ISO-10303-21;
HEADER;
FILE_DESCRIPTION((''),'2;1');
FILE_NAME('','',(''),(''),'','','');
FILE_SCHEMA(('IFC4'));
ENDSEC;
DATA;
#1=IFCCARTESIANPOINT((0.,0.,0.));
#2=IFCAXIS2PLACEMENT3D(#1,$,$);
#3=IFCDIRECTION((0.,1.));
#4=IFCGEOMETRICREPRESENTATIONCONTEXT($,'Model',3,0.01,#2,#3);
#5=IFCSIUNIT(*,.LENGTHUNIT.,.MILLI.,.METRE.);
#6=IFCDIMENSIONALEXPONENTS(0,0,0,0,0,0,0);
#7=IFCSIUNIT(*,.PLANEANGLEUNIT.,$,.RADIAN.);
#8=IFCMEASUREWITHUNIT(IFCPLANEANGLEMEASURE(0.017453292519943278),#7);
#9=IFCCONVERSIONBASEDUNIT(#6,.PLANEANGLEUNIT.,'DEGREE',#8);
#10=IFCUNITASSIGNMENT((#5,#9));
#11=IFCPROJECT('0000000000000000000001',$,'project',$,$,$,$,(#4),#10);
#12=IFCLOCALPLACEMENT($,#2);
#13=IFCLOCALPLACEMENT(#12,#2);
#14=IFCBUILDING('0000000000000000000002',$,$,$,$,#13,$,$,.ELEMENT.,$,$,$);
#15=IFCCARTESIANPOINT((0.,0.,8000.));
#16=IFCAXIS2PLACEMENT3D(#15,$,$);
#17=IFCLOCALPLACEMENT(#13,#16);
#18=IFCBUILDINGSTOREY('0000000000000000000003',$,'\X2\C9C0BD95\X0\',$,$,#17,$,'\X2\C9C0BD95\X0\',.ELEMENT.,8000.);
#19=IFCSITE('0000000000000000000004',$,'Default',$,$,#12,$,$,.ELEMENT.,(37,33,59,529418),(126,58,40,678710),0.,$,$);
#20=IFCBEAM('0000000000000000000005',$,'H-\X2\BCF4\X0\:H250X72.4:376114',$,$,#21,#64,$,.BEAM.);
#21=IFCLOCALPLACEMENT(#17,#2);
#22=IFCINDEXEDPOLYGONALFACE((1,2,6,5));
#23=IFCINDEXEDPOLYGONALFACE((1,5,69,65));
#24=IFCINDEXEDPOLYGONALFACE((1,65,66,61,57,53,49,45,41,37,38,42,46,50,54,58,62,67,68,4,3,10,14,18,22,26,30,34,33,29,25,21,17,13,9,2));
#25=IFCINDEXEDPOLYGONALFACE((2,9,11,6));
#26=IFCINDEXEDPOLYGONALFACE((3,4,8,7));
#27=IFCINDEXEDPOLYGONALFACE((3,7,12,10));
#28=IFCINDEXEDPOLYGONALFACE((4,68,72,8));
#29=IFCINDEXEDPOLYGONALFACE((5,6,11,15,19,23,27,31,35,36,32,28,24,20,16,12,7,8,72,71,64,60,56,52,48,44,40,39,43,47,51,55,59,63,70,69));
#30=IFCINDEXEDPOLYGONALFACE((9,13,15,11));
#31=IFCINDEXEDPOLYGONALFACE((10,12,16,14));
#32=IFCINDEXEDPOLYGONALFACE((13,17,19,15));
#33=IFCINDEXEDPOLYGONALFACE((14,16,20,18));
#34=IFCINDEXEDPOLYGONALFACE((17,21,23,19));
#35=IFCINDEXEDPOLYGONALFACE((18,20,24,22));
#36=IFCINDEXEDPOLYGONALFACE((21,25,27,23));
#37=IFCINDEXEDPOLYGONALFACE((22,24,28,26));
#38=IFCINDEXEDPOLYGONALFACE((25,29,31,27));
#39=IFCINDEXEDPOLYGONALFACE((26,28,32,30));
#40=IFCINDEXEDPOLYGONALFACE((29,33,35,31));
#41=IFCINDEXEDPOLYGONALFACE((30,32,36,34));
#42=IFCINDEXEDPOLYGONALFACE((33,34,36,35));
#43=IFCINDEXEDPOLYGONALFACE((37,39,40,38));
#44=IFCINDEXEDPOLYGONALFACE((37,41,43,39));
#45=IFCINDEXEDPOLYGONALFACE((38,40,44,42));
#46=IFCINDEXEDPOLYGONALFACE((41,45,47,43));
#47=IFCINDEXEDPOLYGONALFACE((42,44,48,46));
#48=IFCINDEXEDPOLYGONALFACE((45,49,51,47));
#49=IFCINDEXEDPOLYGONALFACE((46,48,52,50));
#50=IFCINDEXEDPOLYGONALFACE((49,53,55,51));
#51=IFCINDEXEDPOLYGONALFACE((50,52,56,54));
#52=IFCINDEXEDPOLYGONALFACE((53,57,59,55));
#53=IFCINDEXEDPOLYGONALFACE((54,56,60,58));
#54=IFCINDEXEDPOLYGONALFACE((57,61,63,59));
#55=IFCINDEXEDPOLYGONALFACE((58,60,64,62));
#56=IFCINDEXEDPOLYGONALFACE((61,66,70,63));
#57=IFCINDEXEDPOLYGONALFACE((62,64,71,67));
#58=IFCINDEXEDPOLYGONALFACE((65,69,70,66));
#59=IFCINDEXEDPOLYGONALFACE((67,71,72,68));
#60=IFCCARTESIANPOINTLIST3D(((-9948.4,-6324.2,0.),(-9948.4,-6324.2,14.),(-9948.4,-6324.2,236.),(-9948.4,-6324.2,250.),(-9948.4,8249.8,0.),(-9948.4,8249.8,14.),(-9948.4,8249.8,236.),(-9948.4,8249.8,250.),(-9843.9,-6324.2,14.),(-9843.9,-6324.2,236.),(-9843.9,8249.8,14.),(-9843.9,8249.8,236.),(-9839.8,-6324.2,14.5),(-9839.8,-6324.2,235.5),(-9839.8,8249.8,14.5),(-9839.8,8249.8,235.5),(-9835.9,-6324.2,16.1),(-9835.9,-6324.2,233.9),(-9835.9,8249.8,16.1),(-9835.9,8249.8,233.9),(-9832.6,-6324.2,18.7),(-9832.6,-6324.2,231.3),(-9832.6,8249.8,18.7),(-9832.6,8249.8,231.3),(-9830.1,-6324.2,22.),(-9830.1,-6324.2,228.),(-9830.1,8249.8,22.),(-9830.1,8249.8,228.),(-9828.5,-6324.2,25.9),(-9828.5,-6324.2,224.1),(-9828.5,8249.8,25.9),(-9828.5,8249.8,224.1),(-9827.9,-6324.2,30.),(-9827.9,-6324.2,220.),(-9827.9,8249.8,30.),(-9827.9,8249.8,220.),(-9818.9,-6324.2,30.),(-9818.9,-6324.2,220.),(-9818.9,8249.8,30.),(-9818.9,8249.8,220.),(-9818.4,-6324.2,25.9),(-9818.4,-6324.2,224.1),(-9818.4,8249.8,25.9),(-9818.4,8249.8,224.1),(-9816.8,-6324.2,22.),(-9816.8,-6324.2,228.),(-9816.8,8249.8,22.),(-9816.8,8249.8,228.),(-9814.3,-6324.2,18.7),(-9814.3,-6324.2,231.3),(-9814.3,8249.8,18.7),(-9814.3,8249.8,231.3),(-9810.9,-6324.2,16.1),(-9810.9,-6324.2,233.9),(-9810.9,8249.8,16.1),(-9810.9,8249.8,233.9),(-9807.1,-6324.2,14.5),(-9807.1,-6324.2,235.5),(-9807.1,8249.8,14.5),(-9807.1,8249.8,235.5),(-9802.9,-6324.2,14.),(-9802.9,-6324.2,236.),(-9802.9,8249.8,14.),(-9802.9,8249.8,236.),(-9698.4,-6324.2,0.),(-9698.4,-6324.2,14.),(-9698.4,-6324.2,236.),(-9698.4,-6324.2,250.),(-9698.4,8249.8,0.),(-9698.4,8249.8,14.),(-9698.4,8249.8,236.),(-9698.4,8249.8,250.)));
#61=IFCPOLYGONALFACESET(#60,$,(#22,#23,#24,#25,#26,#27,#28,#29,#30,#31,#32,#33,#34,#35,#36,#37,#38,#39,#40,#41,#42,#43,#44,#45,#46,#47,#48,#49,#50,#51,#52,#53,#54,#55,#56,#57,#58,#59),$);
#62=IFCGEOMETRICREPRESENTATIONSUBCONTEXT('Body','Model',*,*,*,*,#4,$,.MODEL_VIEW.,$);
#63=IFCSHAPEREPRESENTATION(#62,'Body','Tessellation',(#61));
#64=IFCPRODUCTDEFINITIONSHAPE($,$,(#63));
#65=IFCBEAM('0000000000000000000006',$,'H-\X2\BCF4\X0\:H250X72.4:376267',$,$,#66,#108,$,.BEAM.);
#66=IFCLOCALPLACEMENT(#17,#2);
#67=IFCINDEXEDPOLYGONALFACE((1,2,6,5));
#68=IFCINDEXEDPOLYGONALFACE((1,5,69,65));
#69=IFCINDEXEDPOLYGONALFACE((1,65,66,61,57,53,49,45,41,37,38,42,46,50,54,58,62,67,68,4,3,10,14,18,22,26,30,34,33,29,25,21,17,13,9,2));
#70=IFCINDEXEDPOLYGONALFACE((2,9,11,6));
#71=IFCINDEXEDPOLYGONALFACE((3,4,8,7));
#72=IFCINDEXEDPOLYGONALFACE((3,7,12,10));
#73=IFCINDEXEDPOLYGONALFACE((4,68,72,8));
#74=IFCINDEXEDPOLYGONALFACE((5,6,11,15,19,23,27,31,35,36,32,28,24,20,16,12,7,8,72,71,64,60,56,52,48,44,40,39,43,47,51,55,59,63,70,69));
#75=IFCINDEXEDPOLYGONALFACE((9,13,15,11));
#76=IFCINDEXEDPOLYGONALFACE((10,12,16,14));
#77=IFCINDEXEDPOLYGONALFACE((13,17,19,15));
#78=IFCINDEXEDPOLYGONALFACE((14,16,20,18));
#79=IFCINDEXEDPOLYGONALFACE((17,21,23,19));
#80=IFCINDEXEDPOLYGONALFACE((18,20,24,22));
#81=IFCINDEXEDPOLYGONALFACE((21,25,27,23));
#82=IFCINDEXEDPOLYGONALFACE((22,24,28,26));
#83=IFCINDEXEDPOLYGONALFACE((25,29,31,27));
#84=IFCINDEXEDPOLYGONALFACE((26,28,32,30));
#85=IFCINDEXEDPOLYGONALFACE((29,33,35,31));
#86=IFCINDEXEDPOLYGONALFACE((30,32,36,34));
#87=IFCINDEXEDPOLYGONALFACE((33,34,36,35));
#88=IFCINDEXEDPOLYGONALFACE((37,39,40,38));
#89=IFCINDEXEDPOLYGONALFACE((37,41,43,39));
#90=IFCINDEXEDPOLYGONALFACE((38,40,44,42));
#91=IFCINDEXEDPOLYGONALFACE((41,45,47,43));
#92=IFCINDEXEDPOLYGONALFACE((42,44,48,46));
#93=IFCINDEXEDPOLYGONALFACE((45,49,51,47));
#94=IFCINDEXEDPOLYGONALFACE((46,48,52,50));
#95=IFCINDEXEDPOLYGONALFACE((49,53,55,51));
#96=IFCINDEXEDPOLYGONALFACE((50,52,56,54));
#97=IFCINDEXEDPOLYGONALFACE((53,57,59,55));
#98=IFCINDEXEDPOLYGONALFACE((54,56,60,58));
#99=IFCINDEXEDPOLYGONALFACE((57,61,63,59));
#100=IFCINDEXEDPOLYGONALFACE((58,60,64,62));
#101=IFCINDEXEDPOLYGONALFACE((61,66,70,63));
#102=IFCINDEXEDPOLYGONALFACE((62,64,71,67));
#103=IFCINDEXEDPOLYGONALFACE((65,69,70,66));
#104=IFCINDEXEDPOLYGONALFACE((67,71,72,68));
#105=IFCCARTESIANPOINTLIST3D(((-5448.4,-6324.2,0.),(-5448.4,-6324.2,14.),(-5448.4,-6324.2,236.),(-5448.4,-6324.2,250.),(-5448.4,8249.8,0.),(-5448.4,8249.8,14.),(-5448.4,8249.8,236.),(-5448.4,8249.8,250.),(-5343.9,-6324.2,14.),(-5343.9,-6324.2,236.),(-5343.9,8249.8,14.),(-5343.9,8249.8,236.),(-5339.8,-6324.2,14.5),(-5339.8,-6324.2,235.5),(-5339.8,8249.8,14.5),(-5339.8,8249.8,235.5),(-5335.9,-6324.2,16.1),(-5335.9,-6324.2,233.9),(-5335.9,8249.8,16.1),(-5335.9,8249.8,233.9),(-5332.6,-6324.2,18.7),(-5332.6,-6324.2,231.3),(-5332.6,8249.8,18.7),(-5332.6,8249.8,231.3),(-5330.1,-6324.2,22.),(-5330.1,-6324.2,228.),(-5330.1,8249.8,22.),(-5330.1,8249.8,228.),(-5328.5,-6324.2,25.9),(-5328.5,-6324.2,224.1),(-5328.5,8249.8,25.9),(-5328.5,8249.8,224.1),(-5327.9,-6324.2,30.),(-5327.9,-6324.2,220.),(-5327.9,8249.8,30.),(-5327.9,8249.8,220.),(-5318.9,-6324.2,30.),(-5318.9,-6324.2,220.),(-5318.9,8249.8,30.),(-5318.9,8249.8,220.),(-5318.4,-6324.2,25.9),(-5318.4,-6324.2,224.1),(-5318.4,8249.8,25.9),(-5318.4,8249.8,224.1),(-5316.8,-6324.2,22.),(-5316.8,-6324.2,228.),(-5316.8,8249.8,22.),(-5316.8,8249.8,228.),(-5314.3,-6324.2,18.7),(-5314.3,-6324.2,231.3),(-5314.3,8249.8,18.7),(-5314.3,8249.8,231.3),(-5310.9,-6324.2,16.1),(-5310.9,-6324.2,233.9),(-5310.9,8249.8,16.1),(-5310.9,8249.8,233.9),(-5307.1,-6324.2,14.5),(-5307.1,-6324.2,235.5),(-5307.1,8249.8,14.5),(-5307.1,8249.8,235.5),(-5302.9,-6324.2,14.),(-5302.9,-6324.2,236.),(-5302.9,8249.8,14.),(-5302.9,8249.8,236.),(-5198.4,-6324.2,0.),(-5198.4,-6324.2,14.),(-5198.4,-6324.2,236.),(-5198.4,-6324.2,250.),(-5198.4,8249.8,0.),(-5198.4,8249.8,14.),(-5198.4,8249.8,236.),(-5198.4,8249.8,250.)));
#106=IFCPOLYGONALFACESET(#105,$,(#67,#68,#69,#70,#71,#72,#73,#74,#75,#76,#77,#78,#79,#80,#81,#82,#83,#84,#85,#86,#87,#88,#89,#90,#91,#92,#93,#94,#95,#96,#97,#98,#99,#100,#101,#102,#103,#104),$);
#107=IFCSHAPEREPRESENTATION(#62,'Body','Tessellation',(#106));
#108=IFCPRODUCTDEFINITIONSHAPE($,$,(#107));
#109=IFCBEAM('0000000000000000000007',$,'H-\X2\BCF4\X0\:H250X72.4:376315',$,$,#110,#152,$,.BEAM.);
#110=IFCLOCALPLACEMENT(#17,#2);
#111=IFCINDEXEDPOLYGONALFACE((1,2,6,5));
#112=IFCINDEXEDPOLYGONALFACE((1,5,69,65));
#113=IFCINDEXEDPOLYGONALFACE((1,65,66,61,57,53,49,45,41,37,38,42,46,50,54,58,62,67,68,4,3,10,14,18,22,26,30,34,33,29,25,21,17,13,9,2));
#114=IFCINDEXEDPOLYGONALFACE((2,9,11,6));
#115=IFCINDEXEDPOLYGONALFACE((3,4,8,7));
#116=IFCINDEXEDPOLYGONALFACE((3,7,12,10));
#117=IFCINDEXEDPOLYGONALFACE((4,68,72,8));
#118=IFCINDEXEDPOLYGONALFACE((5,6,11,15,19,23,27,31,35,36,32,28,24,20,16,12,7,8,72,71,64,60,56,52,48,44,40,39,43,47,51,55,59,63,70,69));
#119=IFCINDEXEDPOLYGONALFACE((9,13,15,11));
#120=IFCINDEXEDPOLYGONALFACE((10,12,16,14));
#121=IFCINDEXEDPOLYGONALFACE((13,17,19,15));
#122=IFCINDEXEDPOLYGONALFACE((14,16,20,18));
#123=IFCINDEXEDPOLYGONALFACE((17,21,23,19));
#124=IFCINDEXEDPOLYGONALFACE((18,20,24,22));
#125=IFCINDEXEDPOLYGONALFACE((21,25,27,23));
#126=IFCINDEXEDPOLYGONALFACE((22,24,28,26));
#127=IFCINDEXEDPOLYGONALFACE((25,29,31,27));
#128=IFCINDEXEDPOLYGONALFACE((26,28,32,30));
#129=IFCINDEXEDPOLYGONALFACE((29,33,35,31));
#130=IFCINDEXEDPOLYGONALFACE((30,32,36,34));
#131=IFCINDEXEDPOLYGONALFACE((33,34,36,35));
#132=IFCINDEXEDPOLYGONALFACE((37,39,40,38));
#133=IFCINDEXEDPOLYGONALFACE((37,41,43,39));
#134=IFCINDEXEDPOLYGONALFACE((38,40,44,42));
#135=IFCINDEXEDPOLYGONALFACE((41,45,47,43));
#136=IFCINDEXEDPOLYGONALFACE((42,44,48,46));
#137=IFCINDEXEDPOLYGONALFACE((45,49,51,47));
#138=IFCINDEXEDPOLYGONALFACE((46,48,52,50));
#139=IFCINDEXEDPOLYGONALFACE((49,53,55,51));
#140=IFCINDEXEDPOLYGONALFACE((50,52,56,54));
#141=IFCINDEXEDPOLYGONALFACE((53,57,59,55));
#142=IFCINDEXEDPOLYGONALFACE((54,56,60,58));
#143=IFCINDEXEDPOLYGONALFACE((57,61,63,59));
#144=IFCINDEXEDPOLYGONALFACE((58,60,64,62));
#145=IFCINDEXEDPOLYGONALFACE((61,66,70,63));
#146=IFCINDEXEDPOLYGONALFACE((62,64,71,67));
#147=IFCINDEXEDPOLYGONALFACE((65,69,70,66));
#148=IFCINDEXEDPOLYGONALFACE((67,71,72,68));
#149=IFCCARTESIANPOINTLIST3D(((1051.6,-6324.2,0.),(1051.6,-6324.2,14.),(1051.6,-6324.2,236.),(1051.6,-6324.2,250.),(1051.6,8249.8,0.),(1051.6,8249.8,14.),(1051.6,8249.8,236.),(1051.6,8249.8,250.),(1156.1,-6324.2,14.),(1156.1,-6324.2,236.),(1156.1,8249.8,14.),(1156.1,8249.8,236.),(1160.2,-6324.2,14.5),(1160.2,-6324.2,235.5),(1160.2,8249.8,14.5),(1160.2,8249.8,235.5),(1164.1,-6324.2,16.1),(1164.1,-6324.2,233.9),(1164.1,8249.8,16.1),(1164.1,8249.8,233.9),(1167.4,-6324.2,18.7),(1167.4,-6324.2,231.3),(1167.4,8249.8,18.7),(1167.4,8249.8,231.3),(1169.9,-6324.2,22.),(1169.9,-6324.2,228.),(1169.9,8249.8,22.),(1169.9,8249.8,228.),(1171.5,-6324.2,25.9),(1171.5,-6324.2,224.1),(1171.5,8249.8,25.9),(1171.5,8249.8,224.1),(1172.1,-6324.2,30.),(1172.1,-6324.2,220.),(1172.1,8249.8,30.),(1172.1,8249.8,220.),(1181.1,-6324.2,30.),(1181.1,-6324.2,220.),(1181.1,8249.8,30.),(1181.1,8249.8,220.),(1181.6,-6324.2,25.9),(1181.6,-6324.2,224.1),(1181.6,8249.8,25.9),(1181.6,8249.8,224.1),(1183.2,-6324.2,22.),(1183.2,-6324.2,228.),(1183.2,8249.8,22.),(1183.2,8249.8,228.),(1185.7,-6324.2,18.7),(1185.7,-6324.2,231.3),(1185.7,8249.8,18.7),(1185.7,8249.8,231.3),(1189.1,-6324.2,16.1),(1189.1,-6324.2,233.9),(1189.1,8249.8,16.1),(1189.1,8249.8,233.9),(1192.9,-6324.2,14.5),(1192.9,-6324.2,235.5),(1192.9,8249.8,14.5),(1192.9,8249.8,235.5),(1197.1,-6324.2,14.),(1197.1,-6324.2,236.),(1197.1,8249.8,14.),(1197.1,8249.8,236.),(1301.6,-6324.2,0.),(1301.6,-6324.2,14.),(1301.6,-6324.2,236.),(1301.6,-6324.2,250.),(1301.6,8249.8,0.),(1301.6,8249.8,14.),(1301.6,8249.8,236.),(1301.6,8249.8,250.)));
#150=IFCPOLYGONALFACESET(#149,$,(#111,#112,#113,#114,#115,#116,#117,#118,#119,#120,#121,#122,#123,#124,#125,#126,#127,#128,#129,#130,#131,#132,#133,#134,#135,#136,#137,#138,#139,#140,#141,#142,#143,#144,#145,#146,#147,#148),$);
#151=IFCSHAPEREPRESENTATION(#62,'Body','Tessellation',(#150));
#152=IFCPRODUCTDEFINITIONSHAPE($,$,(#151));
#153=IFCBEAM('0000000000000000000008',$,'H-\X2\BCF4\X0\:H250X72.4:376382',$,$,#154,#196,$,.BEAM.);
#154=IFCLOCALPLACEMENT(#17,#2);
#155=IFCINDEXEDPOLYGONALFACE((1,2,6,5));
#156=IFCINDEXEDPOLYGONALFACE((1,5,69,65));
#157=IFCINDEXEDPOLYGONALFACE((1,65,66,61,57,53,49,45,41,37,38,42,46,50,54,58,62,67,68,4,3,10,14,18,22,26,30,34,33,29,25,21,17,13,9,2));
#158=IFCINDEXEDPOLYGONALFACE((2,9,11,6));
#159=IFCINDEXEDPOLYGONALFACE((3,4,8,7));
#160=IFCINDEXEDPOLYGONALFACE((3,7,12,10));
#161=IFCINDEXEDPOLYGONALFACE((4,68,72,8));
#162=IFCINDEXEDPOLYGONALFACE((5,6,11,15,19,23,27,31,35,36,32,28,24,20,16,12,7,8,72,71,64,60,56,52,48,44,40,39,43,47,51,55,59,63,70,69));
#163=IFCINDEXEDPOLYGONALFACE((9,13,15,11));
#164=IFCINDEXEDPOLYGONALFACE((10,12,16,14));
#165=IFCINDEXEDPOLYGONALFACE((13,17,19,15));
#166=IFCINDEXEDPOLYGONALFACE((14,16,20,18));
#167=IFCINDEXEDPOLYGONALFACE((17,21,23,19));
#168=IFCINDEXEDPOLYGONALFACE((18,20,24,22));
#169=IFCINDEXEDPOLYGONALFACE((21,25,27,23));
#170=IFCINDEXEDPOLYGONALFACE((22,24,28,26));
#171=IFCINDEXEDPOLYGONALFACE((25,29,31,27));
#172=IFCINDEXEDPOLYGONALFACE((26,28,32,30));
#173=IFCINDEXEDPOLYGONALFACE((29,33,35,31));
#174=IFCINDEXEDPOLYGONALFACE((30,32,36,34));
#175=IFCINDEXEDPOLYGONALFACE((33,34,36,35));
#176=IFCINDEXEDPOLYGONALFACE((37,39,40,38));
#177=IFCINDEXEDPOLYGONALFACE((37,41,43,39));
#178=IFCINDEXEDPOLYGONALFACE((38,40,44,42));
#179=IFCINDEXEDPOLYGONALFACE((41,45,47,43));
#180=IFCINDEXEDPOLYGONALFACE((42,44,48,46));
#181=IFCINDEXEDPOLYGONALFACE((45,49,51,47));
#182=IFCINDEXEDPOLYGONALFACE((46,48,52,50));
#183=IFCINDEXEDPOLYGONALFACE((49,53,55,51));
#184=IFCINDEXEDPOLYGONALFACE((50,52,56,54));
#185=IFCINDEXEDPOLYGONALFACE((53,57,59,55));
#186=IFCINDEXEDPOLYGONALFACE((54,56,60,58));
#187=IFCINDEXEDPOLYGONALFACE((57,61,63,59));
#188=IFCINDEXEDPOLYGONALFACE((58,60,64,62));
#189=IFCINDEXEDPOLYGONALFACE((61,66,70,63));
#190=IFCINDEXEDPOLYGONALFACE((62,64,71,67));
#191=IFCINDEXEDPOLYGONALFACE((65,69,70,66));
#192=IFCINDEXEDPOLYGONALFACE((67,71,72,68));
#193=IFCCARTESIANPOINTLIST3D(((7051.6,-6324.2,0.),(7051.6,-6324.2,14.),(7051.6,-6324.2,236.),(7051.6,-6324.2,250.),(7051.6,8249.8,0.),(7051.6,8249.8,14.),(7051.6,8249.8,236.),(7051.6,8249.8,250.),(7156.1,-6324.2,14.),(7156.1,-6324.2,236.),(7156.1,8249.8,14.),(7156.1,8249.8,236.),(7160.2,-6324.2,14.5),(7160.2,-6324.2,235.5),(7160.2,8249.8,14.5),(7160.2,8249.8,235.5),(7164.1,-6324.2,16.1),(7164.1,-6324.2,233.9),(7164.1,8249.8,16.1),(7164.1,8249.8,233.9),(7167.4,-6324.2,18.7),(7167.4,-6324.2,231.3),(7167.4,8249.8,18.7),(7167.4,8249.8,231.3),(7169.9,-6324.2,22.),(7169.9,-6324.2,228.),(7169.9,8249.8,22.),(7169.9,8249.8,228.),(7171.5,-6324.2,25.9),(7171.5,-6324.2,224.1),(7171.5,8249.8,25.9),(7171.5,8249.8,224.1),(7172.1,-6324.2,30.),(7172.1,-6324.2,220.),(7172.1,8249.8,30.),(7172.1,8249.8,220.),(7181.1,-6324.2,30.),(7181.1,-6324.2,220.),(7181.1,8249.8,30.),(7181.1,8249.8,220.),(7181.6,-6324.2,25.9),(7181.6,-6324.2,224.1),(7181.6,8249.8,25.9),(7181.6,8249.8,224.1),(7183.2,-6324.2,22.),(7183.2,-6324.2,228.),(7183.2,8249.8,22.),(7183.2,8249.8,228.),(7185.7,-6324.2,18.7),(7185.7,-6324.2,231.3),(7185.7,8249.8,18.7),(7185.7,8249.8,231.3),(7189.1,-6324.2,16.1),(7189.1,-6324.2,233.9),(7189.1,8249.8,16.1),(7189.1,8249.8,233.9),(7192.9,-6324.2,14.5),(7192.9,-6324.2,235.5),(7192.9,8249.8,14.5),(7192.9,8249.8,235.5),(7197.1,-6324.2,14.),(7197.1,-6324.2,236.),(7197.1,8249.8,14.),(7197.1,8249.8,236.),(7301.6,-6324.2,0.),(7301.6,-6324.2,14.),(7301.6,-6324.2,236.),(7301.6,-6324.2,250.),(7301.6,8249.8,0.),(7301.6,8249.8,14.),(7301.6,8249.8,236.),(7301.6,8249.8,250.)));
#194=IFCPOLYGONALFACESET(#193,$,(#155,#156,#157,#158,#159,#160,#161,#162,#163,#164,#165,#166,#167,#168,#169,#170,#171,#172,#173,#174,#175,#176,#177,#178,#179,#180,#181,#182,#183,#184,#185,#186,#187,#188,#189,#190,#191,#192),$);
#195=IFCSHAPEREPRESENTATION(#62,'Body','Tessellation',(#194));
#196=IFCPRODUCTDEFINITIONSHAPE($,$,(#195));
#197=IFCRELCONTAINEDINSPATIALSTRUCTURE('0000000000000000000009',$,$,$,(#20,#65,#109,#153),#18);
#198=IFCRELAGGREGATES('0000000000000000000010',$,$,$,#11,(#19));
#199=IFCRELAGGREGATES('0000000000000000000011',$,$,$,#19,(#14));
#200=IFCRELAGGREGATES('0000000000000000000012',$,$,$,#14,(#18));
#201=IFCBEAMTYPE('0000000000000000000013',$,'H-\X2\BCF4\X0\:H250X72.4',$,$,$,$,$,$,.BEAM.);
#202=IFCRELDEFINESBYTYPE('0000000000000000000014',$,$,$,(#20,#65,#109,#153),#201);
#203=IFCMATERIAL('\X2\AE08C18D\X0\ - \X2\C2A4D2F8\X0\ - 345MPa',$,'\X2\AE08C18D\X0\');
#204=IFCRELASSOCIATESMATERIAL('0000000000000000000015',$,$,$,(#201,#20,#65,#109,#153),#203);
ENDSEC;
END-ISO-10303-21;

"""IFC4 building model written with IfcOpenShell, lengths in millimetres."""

from ifc_helpers import new_model, entity, si_unit, converted_unit, direction, frame, origin, place, context, subcontext, project, spatial, line, arc, indexed_curve, outline, extrude, source, transform, mapped, material, type_object, type_shapes, element, save


model = new_model("IFC4")

# Units and contexts
model_context = context("Model", 3, precision=0.01, world=origin(), true_north=direction((0.0, 1.0)))
body_context = subcontext(model_context, "Body", "Model", "MODEL_VIEW")
ifc_project = project(units=[si_unit("LENGTHUNIT", "METRE", prefix="MILLI"), converted_unit("PLANEANGLEUNIT", "DEGREE", entity("IfcPlaneAngleMeasure", 0.017453292519943278), si_unit("PLANEANGLEUNIT", "RADIAN"), dimensions=[0, 0, 0, 0, 0, 0, 0])], contexts=[model_context])

# Site, building, storey
site_placement = place(None, origin())
site = spatial("IfcSite", under=ifc_project, at=site_placement, Name="Default", CompositionType="ELEMENT", RefLatitude=(37, 33, 59, 529418), RefLongitude=(126, 58, 40, 678710), RefElevation=0.0)
building_placement = place(site_placement, origin())
building = spatial("IfcBuilding", under=site, at=building_placement, CompositionType="ELEMENT")
storey_placement = place(building_placement, frame((0.0, 0.0, 8000.0)))
storey = spatial("IfcBuildingStorey", under=building, at=storey_placement, Name="지붕", LongName="지붕", CompositionType="ELEMENT", Elevation=8000.0)

# Beams
ifc_material = material(Name="금속 - 스틸 - 345MPa", Category="금속")
beam_type_1 = type_object("IfcBeamType", Name="H-보:H250X72.4", PredefinedType="BEAM", material=ifc_material)
shared_shape_1 = source(origin(), body_context, "Body", "SweptSolid", [
    extrude(outline(indexed_curve([(-125.0, -111.0), (-125.0, -125.0), (125.0, -125.0), (125.0, -111.0), (20.5, -111.0), (9.2, -106.3), (4.5, -95.0), (4.5, 95.0), (9.2, 106.3), (20.5, 111.0), (125.0, 111.0), (125.0, 125.0), (-125.0, 125.0), (-125.0, 111.0), (-20.5, 111.0), (-9.2, 106.3), (-4.5, 95.0), (-4.5, -95.0), (-9.2, -106.3), (-20.5, -111.0)], segments=[line(1, 2, 3, 4, 5), arc(5, 6, 7), line(7, 8), arc(8, 9, 10), line(10, 11, 12, 13, 14, 15), arc(15, 16, 17), line(17, 18), arc(18, 19, 20), line(20, 1)], self_intersect=False)), frame((-7287.0, 0.0, 0.0), z_axis=(-1.0, 0.0, 0.0), x_axis=(0.0, -1.0, 0.0)), (0.0, 0.0, -1.0), 14574.0),
])
type_shapes(beam_type_1, [shared_shape_1])
for number, where, z_axis, x_axis, name in (
    (1, (-9823.4, 962.8, 125.0), (0.0, 0.0, 1.0), (0.0, -1.0, 0.0), "H-보:H250X72.4:376114"),
    (2, (-5323.4, 962.8, 125.0), (0.0, 0.0, 1.0), (0.0, -1.0, 0.0), "H-보:H250X72.4:376267"),
    (3, (1176.6, 962.8, 125.0), (0.0, 0.0, 1.0), (0.0, -1.0, 0.0), "H-보:H250X72.4:376315"),
    (4, (7176.6, 962.8, 125.0), (0.0, 0.0, 1.0), (0.0, -1.0, 0.0), "H-보:H250X72.4:376382"),
):
    element("IfcBeam", number, at=place(storey_placement, frame(where, z_axis=z_axis, x_axis=x_axis)), inside=storey, type_object=beam_type_1, material=ifc_material, Name=name, PredefinedType="BEAM", context=body_context, shape_type="MappedRepresentation", body=[
        mapped(shared_shape_1, transform((0.0, 0.0, 0.0), scale=1.0)),
    ])

save(model, "model.ifc")
